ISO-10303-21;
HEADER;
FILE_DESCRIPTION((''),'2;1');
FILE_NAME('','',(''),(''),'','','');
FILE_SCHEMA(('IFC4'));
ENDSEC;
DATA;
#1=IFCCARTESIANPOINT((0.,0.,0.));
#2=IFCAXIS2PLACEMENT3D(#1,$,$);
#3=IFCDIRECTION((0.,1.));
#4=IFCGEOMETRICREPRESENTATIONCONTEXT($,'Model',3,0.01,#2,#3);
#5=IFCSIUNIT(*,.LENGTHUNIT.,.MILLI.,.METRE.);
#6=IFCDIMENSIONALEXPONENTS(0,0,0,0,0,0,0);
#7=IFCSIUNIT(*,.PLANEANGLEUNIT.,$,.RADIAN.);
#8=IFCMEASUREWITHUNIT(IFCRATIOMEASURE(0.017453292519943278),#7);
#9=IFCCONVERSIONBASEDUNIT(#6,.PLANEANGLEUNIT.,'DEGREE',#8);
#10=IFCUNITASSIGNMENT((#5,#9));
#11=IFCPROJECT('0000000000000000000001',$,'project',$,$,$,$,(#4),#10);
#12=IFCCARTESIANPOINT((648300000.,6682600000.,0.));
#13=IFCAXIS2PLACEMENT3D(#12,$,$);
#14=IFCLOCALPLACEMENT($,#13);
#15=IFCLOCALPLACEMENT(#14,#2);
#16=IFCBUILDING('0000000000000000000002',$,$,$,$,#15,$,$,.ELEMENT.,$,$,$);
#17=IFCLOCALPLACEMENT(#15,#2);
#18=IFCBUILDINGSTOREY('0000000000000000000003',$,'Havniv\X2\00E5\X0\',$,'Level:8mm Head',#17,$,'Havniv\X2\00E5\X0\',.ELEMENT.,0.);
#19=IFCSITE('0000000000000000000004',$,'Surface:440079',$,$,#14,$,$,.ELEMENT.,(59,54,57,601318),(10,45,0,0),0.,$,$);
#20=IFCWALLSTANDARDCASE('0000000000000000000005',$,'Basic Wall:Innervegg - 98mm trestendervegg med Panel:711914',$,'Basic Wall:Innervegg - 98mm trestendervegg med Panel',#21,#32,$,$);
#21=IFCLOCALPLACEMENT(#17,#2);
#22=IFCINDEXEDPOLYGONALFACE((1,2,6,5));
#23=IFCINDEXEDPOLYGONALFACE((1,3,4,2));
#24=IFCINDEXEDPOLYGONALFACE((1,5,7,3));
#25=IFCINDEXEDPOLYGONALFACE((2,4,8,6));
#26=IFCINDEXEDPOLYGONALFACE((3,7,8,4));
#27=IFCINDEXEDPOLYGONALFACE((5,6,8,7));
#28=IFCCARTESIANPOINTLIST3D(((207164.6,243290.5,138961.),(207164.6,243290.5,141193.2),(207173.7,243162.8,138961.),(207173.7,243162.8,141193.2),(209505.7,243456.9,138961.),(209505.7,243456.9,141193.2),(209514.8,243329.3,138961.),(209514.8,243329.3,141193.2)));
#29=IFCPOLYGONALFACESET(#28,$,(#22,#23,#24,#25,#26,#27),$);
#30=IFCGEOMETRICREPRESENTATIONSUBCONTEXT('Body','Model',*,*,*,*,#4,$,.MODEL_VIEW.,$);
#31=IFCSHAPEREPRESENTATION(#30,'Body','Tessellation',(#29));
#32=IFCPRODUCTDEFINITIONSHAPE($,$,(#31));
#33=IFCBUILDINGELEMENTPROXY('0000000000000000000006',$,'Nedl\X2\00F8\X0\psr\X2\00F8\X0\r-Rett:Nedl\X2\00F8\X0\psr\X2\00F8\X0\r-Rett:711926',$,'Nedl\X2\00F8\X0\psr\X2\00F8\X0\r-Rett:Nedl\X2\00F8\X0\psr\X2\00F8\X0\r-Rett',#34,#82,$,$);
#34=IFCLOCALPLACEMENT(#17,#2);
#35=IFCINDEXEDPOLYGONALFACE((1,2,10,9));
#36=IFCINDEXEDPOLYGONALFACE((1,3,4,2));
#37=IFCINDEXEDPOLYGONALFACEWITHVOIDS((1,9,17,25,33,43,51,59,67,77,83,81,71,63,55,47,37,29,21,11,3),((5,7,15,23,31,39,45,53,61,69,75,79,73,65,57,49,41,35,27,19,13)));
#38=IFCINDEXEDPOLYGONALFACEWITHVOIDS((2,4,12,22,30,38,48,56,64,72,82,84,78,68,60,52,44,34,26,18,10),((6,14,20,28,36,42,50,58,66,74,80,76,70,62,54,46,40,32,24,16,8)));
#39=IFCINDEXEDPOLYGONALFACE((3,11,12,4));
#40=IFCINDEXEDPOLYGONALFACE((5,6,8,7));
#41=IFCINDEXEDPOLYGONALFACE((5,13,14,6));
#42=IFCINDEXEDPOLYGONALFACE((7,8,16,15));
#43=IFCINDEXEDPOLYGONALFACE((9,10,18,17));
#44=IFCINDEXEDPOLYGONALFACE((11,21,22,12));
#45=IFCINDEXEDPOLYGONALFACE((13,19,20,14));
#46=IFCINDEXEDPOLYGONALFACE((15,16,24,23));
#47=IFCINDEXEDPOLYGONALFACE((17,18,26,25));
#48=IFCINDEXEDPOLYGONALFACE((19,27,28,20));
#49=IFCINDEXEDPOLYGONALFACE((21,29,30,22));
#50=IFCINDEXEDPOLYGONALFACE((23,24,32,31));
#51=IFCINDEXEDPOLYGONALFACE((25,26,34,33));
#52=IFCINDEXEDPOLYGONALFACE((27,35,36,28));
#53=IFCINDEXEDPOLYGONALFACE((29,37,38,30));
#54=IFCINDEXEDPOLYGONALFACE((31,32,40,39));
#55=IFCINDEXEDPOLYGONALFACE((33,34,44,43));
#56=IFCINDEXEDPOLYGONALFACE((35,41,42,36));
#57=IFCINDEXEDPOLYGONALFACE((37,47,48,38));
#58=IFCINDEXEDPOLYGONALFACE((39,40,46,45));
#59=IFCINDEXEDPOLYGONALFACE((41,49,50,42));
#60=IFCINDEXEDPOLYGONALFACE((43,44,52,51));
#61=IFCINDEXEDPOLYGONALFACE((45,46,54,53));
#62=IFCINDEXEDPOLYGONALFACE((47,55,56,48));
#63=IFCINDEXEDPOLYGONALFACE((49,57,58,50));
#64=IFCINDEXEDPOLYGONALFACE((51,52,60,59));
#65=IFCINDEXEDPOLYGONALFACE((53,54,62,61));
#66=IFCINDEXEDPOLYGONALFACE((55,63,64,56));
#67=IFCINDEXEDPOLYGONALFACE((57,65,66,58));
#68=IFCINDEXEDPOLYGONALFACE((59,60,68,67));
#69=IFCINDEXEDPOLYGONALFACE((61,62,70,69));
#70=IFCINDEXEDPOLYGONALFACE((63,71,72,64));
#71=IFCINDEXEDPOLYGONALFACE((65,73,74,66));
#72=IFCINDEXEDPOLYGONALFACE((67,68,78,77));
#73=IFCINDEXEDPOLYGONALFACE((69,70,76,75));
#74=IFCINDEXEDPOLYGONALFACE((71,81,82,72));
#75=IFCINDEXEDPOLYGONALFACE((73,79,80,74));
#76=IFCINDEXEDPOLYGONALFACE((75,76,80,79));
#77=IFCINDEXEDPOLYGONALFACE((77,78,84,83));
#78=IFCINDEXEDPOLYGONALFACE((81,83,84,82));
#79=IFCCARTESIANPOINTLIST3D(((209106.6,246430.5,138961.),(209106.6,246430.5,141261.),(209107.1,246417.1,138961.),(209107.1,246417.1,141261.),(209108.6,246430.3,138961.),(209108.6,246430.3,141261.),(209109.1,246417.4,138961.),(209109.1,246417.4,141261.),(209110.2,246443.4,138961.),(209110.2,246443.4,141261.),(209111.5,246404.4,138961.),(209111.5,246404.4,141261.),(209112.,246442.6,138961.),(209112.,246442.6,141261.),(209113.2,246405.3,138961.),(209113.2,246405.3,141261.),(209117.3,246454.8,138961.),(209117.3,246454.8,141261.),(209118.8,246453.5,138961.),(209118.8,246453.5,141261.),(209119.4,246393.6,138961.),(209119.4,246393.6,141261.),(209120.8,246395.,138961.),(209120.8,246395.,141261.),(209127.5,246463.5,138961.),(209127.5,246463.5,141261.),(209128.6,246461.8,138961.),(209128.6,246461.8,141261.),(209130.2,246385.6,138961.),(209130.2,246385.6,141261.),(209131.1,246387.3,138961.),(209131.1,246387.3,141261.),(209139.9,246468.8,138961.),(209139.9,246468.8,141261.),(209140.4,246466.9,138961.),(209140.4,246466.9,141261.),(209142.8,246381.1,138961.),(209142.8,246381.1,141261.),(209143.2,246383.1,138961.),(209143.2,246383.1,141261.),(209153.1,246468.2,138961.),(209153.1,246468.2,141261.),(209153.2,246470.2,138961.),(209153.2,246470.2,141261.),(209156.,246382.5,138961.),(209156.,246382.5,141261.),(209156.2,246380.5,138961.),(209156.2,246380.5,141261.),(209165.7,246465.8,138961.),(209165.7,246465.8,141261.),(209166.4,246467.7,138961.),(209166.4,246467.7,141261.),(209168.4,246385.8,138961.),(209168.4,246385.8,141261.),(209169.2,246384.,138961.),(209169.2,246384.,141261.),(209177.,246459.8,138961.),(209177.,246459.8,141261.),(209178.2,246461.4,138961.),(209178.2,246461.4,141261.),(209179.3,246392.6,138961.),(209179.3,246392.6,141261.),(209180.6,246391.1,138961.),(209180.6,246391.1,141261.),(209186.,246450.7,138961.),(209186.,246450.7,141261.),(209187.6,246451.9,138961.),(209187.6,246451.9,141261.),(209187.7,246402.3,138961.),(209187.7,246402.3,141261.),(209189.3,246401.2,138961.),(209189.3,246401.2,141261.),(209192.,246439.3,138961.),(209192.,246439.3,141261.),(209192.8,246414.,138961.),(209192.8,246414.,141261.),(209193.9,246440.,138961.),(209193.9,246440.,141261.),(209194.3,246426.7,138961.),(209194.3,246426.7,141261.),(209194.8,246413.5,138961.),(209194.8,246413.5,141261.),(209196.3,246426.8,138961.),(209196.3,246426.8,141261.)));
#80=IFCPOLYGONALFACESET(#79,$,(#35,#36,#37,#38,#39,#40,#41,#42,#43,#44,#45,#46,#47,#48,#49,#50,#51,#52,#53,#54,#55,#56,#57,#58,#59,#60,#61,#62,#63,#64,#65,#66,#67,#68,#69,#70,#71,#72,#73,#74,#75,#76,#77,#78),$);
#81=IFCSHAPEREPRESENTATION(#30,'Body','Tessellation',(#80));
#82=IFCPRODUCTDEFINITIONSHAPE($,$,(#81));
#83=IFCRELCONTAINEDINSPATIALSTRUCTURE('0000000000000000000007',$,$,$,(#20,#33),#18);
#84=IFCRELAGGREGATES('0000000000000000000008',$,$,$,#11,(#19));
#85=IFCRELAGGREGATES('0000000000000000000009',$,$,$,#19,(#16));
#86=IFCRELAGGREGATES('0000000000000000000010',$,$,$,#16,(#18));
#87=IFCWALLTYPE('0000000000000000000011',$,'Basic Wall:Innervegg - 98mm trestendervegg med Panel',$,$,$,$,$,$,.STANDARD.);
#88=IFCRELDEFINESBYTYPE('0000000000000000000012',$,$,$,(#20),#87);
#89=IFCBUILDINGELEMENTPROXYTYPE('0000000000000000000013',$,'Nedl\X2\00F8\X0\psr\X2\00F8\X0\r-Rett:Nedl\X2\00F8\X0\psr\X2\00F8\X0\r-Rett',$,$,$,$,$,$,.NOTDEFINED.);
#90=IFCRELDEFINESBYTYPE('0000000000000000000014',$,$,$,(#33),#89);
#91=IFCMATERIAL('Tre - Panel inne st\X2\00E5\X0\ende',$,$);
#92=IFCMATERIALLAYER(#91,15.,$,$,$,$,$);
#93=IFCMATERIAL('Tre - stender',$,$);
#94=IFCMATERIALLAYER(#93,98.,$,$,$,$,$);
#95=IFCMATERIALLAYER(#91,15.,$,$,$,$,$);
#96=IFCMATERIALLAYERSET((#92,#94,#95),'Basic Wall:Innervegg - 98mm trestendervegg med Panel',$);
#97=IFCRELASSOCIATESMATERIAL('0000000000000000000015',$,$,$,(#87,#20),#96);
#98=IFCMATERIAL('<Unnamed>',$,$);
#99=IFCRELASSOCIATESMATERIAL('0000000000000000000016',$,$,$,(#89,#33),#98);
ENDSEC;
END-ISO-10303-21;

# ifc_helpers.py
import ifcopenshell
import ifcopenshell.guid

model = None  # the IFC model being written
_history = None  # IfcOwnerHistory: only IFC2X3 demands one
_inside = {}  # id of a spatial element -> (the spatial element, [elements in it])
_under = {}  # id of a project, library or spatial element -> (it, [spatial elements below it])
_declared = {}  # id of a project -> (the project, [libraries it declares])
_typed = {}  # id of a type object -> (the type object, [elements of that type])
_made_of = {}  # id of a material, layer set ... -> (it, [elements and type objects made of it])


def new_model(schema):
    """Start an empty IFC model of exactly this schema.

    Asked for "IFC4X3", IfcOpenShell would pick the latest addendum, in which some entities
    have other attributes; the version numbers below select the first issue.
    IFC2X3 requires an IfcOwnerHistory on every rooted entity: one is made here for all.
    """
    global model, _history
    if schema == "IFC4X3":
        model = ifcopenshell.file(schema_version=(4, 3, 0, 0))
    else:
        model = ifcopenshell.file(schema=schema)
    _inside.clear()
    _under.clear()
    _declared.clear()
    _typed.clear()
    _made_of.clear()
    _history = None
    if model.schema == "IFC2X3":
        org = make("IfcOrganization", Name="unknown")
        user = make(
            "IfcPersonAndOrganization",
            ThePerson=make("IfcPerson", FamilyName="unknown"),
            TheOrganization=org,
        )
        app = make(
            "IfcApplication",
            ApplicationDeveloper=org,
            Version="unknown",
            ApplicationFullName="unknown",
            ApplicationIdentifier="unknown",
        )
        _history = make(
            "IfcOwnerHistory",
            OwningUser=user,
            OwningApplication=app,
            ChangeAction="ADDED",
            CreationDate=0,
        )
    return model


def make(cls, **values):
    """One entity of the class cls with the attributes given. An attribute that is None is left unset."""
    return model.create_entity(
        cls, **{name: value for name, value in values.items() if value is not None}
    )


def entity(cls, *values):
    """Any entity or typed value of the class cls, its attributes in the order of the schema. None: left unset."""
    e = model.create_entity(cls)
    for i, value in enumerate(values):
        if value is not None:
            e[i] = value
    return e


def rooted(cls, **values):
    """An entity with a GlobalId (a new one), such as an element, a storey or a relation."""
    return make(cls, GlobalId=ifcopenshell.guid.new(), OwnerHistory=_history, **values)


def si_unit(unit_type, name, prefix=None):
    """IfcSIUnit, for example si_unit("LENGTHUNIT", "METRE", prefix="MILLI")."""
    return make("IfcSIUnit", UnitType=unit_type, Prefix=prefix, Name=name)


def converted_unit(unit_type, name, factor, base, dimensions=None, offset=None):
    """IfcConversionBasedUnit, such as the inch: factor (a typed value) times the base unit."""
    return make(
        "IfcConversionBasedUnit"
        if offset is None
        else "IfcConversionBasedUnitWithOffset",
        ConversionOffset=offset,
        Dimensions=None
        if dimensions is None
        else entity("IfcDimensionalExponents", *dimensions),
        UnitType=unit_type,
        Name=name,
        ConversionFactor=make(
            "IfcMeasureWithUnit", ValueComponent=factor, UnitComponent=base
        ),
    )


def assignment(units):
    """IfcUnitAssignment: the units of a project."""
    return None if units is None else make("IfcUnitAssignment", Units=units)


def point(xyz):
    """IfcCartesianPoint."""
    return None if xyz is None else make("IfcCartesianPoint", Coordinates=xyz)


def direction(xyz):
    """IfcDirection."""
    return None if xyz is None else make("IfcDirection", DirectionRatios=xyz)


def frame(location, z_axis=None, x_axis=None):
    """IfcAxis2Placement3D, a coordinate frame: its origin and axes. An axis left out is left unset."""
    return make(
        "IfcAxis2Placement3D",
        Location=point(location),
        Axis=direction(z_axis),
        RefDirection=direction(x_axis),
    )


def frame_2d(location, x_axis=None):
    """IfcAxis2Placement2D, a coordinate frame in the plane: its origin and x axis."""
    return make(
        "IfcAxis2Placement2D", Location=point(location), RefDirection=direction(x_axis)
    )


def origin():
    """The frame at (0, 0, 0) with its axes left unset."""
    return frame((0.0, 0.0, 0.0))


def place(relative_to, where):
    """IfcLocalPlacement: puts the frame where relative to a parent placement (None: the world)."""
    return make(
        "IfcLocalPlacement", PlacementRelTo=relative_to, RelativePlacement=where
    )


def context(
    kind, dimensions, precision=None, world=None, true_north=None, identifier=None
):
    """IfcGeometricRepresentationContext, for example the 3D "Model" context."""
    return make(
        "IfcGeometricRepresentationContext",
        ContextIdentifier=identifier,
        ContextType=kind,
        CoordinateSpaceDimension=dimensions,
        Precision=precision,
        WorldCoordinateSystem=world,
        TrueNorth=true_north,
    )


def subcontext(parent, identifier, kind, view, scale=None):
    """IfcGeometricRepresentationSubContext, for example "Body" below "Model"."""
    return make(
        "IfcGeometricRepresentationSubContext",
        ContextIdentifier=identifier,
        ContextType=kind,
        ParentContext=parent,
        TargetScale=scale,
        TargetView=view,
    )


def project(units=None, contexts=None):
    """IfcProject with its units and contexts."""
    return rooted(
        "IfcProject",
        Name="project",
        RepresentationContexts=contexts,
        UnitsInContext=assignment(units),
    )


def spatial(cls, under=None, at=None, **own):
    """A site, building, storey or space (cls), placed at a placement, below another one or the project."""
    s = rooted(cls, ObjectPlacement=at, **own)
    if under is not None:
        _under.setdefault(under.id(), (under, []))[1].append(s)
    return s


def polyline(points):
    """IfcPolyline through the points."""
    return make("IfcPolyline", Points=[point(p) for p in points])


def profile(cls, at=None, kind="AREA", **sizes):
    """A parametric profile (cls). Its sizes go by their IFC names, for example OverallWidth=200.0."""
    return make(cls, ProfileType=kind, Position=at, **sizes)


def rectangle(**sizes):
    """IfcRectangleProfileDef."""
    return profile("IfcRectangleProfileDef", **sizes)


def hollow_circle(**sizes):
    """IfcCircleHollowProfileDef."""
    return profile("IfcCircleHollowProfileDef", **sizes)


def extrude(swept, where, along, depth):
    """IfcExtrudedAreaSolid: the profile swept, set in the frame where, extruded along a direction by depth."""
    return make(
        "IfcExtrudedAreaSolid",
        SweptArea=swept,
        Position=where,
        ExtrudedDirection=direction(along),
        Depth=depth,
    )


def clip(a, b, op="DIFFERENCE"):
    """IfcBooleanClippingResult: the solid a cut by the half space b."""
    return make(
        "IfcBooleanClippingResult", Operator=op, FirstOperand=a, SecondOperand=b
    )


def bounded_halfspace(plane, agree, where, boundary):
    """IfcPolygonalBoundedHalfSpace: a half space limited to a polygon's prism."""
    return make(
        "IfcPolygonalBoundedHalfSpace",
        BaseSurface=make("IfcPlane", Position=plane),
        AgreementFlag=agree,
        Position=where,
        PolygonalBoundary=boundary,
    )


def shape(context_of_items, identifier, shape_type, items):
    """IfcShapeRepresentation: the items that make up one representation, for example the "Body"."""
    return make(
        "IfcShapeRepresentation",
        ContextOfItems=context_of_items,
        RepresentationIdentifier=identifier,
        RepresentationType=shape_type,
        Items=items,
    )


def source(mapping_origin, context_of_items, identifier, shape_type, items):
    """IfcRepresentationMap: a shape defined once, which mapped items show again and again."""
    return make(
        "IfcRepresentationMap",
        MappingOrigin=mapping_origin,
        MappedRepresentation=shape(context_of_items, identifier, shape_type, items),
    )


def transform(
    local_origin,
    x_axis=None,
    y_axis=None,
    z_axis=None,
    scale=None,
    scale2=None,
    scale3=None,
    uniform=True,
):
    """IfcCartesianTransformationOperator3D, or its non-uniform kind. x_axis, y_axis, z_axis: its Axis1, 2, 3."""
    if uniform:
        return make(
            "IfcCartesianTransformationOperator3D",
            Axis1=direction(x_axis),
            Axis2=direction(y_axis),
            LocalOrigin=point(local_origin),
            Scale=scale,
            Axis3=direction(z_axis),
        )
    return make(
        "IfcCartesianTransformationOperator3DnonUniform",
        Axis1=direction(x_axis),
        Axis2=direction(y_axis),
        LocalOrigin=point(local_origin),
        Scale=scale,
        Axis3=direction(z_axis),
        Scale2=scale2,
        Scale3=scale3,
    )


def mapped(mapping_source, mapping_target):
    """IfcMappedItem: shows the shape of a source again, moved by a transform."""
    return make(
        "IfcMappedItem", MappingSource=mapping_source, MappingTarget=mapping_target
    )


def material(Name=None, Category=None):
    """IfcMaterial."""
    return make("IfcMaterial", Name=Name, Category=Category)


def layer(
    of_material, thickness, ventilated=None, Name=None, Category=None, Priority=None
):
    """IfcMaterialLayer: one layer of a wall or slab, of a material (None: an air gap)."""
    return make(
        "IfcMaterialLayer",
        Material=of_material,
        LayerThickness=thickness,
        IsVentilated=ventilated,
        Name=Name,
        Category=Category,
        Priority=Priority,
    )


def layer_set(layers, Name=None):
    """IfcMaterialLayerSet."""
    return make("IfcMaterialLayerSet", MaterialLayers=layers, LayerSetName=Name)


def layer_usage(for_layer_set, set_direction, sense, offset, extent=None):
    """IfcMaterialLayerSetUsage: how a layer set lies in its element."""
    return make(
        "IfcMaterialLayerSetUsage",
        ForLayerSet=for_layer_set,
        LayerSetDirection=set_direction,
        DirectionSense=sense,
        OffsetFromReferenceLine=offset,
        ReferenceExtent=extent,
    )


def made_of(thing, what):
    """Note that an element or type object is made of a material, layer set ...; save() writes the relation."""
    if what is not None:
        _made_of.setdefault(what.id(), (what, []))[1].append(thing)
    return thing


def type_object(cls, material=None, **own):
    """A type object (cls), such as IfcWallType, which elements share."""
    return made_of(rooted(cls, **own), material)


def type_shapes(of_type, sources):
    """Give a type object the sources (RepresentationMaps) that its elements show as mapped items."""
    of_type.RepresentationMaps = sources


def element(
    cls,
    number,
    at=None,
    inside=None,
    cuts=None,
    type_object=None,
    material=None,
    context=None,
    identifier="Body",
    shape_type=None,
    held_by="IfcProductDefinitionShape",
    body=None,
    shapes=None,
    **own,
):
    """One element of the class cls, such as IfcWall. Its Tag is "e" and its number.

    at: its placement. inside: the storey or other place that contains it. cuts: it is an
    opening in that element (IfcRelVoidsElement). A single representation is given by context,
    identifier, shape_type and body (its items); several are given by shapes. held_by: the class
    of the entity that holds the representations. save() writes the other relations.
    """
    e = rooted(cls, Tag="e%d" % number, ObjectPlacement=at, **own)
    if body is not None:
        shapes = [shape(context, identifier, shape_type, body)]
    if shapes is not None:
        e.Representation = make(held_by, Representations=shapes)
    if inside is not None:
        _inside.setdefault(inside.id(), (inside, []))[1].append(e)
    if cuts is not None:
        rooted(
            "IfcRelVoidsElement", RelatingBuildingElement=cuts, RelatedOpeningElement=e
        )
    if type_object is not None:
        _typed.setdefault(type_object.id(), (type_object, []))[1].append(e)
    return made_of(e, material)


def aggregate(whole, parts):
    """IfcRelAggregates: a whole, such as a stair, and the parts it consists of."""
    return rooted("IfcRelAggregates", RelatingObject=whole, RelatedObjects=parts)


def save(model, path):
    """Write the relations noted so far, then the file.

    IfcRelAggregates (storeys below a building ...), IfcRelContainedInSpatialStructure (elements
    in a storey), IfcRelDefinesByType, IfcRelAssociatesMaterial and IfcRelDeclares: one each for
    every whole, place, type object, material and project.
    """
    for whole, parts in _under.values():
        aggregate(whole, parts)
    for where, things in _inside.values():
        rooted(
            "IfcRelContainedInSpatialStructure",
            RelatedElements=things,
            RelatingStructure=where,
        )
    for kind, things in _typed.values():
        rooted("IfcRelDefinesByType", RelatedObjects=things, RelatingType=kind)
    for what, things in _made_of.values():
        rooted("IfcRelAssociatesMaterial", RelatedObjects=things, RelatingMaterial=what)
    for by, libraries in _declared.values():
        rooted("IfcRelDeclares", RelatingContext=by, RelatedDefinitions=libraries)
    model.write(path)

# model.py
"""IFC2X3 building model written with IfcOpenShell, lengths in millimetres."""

from ifc_helpers import new_model, entity, si_unit, converted_unit, direction, frame, frame_2d, origin, place, context, subcontext, project, spatial, polyline, rectangle, hollow_circle, extrude, clip, bounded_halfspace, source, transform, mapped, material, layer, layer_set, layer_usage, type_object, type_shapes, element, save


model = new_model("IFC2X3")

# Units and contexts
model_context = context("Model", 3, precision=0.01, world=origin(), true_north=direction((0.0, 1.0)))
body_context = subcontext(model_context, "Body", "Model", "MODEL_VIEW")
ifc_project = project(units=[si_unit("LENGTHUNIT", "METRE", prefix="MILLI"), converted_unit("PLANEANGLEUNIT", "DEGREE", entity("IfcRatioMeasure", 0.017453292519943278), si_unit("PLANEANGLEUNIT", "RADIAN"), dimensions=[0, 0, 0, 0, 0, 0, 0])], contexts=[model_context])

# Site, building, storey
site_placement = place(None, frame((648300000.0, 6682600000.0, 0.0)))
site = spatial("IfcSite", under=ifc_project, at=site_placement, Name="Surface:440079", CompositionType="ELEMENT", RefLatitude=(59, 54, 57, 601318), RefLongitude=(10, 45, 0, 0), RefElevation=0.0)
building_placement = place(site_placement, origin())
building = spatial("IfcBuilding", under=site, at=building_placement, CompositionType="ELEMENT")
storey_placement = place(building_placement, origin())
storey = spatial("IfcBuildingStorey", under=building, at=storey_placement, Name="Havnivå", ObjectType="Level:8mm Head", LongName="Havnivå", CompositionType="ELEMENT", Elevation=0.0)

# Shared definitions
ifc_material_1 = material(Name="Tre - stender")

# Wall
ifc_material_2 = material(Name="Tre - Panel inne stående")
ifc_layer_1 = layer(ifc_material_2, 15.0)
ifc_layer_2 = layer(ifc_material_1, 98.0)
ifc_layer_3 = layer(ifc_material_2, 15.0)
ifc_layer_set_1 = layer_set([ifc_layer_1, ifc_layer_2, ifc_layer_3], Name="Basic Wall:Innervegg - 98mm trestendervegg med Panel")
wall_type_1 = type_object("IfcWallType", Name="Basic Wall:Innervegg - 98mm trestendervegg med Panel", PredefinedType="STANDARD", material=ifc_layer_set_1)
ifc_layer_usage_1 = layer_usage(ifc_layer_set_1, "AXIS2", "POSITIVE", -64.0)
wall_1_placement = place(storey_placement, frame((207169.2, 243226.7, 138961.0), z_axis=(0.0, 0.0, 1.0), x_axis=(0.997483, 0.070908, 0.0)))
element("IfcWallStandardCase", 1, at=wall_1_placement, inside=storey, type_object=wall_type_1, material=ifc_layer_usage_1, Name="Basic Wall:Innervegg - 98mm trestendervegg med Panel:711914", ObjectType="Basic Wall:Innervegg - 98mm trestendervegg med Panel", context=body_context, shape_type="Clipping", body=[
    clip(extrude(rectangle(XDim=2347.0, YDim=128.0, at=frame_2d((1173.5, 0.0), x_axis=(-1.0, 0.0))), origin(), (0.0, 0.0, 1.0), 2232.2), bounded_halfspace(frame((0.0, -64.0, 2232.2), z_axis=(0.0, 0.0, -1.0), x_axis=(1.0, 0.0, 0.0)), True, frame((0.0, -64.0, 2232.2)), polyline([(0.0, 0.0), (715365.6, 0.0), (715365.6, 39014.4), (0.0, 39014.4), (0.0, 0.0)]))),
])

# Building element proxy
ifc_material_3 = material(Name="<Unnamed>")
building_element_proxy_type = type_object("IfcBuildingElementProxyType", Name="Nedløpsrør-Rett:Nedløpsrør-Rett", PredefinedType="NOTDEFINED", material=ifc_material_3)
shared_shape_1 = source(origin(), body_context, "Body", "SweptSolid", [
    extrude(hollow_circle(Radius=45.0, WallThickness=2.0, at=frame_2d((0.0, 0.0), x_axis=(1.0, 0.0))), frame((0.0, 0.0, 0.0), z_axis=(0.0, 0.0, 1.0), x_axis=(-1.0, 0.0, 0.0)), (0.0, 0.0, 1.0), 2300.0),
])
type_shapes(building_element_proxy_type, [shared_shape_1])
proxy_placement = place(storey_placement, frame((209151.3, 246425.3, 138961.0), z_axis=(0.0, 0.0, 1.0), x_axis=(0.755467, -0.655187, 0.0)))
element("IfcBuildingElementProxy", 2, at=proxy_placement, inside=storey, type_object=building_element_proxy_type, material=ifc_material_3, Name="Nedløpsrør-Rett:Nedløpsrør-Rett:711926", ObjectType="Nedløpsrør-Rett:Nedløpsrør-Rett", context=body_context, shape_type="MappedRepresentation", body=[
    mapped(shared_shape_1, transform((0.0, 0.0, 0.0), scale=1.0)),
])

save(model, "model.ifc")
